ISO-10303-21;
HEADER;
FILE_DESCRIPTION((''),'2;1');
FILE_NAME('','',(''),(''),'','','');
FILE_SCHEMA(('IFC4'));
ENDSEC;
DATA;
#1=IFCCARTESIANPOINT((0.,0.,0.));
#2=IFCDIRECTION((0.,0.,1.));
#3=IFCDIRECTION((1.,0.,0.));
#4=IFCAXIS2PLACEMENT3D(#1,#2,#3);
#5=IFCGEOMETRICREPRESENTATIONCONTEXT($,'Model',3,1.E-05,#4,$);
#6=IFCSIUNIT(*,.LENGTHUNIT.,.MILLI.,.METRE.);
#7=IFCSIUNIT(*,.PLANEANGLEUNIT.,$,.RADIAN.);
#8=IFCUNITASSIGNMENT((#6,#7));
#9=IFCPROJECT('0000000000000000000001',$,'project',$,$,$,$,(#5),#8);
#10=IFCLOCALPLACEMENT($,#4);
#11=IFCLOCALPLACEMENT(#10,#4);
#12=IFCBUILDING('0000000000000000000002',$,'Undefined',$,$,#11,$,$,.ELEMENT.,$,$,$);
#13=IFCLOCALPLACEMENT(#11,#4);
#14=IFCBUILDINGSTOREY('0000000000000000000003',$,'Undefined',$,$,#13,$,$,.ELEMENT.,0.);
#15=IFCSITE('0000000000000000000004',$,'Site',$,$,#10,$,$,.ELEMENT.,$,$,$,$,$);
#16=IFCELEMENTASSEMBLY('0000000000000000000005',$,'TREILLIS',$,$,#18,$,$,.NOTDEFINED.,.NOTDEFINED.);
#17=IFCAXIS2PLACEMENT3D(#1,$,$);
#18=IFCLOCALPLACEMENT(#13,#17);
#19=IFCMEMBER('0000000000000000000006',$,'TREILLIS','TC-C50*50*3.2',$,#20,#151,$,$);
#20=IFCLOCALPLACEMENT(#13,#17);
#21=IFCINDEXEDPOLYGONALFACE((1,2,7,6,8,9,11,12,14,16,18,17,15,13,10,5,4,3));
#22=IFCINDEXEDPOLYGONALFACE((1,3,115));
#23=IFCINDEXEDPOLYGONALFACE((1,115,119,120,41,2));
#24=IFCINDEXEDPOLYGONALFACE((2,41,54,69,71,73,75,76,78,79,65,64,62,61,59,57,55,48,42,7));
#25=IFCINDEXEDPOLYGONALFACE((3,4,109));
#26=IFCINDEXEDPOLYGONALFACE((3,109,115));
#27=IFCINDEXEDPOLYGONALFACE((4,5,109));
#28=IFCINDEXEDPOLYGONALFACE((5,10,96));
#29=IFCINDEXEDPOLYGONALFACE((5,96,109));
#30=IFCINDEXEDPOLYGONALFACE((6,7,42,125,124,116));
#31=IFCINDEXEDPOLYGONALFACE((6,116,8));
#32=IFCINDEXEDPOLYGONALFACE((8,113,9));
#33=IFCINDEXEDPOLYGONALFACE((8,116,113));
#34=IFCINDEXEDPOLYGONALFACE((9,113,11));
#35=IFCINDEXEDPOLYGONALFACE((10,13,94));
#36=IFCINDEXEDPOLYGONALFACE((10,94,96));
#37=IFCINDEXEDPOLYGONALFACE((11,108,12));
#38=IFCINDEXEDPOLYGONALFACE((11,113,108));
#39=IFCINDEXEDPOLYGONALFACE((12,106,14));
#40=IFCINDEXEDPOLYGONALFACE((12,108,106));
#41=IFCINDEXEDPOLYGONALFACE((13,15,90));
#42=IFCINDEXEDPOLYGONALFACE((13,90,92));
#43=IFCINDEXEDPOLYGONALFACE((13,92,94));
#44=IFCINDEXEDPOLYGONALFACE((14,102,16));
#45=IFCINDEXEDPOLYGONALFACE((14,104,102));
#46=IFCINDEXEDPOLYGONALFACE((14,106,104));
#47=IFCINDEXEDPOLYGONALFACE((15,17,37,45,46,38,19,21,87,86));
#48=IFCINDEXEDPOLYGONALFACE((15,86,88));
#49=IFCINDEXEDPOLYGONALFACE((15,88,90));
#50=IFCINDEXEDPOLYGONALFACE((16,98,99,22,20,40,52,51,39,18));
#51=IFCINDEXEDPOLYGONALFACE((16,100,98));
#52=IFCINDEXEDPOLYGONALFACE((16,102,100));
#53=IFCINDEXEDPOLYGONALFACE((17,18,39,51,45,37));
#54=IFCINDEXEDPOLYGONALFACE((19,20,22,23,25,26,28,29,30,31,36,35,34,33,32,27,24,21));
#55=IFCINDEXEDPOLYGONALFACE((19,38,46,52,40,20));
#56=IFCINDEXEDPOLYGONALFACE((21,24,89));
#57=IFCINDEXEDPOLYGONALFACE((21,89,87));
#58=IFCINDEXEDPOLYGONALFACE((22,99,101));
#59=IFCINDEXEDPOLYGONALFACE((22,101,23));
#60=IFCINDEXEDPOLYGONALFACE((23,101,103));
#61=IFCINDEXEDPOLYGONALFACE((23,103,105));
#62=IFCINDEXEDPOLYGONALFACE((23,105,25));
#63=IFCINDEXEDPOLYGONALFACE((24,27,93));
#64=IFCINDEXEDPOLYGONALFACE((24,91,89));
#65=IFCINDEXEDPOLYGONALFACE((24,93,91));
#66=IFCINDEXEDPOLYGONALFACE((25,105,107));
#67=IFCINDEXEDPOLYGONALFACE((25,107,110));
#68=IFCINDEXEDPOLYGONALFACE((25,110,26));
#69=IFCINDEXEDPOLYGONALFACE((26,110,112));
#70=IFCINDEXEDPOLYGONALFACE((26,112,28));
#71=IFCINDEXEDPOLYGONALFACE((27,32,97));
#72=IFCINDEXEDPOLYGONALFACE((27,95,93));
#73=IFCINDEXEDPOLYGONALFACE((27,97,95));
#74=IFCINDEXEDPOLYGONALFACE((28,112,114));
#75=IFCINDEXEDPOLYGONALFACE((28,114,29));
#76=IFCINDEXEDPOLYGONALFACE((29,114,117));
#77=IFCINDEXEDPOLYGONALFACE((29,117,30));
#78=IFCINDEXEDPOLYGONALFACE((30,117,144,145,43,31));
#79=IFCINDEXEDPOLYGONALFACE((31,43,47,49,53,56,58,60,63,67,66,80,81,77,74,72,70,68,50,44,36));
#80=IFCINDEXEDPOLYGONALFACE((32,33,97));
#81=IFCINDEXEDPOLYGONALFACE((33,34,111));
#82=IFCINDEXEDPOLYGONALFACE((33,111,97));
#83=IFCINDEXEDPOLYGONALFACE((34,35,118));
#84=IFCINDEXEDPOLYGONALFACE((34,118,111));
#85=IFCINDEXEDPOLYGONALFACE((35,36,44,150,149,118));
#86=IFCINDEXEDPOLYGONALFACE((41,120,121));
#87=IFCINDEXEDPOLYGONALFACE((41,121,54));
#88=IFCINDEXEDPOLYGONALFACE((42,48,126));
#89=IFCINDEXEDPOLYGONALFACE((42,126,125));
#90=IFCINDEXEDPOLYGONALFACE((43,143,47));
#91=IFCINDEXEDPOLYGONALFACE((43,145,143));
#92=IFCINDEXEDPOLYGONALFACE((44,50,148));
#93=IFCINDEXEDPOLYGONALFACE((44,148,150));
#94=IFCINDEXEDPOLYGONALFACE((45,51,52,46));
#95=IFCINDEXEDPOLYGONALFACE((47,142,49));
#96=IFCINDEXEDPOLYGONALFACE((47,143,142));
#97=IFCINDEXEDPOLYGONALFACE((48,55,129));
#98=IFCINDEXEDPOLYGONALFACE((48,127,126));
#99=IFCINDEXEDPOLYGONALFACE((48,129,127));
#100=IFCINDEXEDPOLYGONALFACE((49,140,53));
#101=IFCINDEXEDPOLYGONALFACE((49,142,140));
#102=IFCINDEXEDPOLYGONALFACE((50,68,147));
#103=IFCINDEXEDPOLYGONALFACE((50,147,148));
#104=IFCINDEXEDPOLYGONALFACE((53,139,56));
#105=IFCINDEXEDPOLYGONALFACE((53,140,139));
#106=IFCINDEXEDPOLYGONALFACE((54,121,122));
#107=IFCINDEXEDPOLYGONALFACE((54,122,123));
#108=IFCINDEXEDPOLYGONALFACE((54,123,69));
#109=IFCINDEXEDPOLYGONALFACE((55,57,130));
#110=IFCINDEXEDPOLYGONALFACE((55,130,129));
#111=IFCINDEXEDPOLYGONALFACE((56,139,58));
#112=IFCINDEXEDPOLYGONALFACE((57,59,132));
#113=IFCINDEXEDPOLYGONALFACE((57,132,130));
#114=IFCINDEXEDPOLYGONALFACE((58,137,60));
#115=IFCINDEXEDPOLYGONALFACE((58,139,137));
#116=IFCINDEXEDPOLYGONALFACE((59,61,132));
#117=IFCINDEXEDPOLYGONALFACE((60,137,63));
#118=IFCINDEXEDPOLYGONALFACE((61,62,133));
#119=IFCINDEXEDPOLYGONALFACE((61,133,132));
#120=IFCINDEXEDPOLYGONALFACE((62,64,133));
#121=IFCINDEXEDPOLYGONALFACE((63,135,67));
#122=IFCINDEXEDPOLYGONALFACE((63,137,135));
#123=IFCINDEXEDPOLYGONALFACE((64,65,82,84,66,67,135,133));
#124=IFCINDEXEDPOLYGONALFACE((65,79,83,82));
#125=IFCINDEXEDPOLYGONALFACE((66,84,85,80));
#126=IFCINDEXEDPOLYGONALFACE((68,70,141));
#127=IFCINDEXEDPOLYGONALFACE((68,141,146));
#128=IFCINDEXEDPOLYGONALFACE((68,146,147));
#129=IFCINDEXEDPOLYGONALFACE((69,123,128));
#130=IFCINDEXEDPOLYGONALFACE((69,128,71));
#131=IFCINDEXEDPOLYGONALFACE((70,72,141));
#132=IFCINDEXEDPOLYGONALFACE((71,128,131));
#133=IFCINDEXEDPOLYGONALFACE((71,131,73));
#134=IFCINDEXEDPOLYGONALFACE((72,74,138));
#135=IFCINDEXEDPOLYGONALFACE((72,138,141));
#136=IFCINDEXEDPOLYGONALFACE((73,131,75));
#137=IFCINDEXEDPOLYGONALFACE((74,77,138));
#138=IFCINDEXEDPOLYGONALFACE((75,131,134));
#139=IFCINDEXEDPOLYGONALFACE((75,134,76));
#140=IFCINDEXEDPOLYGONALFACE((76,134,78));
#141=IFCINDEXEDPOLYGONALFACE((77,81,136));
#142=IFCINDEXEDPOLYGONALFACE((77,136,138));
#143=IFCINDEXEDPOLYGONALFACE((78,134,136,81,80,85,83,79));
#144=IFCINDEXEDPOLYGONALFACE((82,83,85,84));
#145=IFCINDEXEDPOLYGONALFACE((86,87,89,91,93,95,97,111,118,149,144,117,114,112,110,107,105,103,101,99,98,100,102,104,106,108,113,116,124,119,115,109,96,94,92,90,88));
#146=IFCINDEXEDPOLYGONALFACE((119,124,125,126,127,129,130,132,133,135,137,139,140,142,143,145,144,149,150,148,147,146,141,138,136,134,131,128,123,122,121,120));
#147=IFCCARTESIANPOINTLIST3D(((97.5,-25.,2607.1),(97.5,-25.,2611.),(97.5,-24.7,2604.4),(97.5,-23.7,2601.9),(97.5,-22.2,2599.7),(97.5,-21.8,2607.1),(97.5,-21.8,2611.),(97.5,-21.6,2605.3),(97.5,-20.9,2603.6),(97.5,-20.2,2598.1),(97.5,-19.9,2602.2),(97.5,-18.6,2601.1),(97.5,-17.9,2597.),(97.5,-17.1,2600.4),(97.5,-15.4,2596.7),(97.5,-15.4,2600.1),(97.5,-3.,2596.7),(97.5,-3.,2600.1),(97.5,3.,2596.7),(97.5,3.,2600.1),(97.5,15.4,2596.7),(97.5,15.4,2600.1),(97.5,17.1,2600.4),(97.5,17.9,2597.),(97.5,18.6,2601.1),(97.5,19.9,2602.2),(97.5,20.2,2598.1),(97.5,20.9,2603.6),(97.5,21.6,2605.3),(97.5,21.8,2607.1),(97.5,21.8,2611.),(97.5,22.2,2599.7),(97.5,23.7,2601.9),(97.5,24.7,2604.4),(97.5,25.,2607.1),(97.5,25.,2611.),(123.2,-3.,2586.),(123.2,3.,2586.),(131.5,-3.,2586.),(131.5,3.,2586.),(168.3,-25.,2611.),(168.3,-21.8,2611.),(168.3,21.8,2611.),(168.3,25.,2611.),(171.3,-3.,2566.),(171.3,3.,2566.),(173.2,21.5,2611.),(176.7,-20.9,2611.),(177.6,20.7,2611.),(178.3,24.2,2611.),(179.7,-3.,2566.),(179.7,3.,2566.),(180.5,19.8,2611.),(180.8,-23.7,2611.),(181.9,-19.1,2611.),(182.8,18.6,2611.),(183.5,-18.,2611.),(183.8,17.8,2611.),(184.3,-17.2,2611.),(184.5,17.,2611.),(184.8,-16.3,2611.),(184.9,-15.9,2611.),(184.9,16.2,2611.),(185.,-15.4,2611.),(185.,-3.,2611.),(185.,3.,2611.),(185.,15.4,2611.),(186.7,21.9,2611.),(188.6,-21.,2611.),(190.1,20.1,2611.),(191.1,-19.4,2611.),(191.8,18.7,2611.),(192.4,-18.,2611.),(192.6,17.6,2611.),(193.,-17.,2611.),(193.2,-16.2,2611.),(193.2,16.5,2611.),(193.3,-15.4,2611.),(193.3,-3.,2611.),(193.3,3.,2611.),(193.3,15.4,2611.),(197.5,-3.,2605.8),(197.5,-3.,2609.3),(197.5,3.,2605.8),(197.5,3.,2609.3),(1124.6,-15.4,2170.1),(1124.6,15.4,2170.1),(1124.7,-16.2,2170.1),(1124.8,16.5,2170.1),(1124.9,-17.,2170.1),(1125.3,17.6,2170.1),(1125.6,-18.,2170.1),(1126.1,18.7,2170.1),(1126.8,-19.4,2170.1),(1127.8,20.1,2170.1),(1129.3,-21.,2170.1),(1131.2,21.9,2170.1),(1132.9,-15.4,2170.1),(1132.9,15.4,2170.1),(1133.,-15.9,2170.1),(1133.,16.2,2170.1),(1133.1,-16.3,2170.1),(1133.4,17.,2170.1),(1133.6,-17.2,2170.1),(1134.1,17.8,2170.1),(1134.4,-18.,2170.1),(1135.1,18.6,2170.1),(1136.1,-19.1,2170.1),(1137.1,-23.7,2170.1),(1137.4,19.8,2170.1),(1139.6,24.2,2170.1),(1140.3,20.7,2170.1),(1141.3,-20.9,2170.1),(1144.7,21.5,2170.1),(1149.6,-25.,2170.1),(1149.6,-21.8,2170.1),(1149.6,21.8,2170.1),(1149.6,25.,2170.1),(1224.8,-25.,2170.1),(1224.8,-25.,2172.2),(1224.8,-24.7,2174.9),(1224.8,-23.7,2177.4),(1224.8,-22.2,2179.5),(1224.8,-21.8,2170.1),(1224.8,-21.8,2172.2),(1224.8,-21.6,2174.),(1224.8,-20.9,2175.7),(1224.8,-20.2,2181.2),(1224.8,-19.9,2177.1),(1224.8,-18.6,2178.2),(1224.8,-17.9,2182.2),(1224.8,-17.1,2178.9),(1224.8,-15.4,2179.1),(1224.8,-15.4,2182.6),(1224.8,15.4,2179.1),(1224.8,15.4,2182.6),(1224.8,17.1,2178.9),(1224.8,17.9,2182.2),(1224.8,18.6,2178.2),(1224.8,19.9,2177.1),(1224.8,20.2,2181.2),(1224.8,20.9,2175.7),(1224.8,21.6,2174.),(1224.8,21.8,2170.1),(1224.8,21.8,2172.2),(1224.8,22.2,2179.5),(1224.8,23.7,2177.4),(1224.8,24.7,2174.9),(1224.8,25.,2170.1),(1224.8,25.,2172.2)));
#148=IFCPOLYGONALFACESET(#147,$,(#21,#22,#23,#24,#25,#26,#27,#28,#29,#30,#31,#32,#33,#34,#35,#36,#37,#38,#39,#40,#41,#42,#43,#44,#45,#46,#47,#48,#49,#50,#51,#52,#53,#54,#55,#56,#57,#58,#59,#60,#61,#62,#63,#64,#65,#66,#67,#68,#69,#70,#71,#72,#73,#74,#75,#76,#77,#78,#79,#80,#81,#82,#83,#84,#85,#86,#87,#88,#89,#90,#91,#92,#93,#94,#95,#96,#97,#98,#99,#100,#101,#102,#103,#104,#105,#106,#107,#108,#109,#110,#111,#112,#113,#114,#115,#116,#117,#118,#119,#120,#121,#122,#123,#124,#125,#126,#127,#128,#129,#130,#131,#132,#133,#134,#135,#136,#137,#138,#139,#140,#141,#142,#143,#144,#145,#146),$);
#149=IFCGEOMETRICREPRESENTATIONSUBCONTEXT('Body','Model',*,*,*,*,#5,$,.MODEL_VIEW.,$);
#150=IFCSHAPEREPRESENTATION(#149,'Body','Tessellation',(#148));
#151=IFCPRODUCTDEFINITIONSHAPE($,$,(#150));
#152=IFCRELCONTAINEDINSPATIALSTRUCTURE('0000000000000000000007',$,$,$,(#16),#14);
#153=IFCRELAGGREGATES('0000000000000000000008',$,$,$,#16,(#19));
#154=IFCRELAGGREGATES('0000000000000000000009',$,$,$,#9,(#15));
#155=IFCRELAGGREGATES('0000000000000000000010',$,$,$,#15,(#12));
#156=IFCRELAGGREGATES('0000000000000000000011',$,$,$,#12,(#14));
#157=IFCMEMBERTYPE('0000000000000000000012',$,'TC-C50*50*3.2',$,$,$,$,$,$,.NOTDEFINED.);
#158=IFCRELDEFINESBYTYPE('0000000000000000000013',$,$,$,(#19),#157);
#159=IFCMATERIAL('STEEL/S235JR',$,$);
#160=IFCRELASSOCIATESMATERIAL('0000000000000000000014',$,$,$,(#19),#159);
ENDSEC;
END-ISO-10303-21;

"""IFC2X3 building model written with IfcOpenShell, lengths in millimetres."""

from ifc_helpers import new_model, si_unit, frame, origin_with_axes, origin_2d_with_axis, place, context, subcontext, project, spatial, rectangle, hollow_rectangle, extrude, boolean, halfspace, material, type_object, element, aggregate, save


model = new_model("IFC2X3")

# Units and contexts
model_context = context("Model", 3, precision=1e-05, world=origin_with_axes())
body_context = subcontext(model_context, "Body", "Model", "MODEL_VIEW")
ifc_project = project(units=[si_unit("LENGTHUNIT", "METRE", prefix="MILLI"), si_unit("PLANEANGLEUNIT", "RADIAN")], contexts=[model_context])

# Site, building, storey
site_placement = place(None, origin_with_axes())
site = spatial("IfcSite", under=ifc_project, at=site_placement, Name="Site", CompositionType="ELEMENT")
building_placement = place(site_placement, origin_with_axes())
building = spatial("IfcBuilding", under=site, at=building_placement, Name="Undefined", CompositionType="ELEMENT")
storey_placement = place(building_placement, origin_with_axes())
storey = spatial("IfcBuildingStorey", under=building, at=storey_placement, Name="Undefined", CompositionType="ELEMENT", Elevation=0.0)

# Shared definitions
ifc_material_1 = material(Name="STEEL/S235JR")

# Element assembly
assembly_1_placement = place(storey_placement, origin_with_axes())
assembly_1 = element("IfcElementAssembly", 1, at=assembly_1_placement, inside=storey, Name="TREILLIS", AssemblyPlace="NOTDEFINED", PredefinedType="NOTDEFINED")

# Member
member_type = type_object("IfcMemberType", Name="TC-C50*50*3.2", PredefinedType="NOTDEFINED")
member_1_placement = place(assembly_1_placement, frame((1249.8, 0.0, 2145.1), z_axis=(0.383566, 0.0, 0.923513), x_axis=(-0.923513, 0.0, 0.383566)))
solid = boolean("DIFFERENCE", boolean("DIFFERENCE", boolean("DIFFERENCE", boolean("DIFFERENCE", boolean("DIFFERENCE", boolean("DIFFERENCE", boolean("DIFFERENCE", boolean("DIFFERENCE", extrude(hollow_rectangle(XDim=50.0, YDim=50.0, WallThickness=3.2, InnerFilletRadius=6.4, OuterFilletRadius=9.6, at=origin_2d_with_axis()), frame((1280.0, 0.0, 0.0), z_axis=(-1.0, 0.0, 0.0), x_axis=(0.0, -1.0, 0.0)), (0.0, 0.0, 1.0), 1280.0), extrude(rectangle(XDim=6.0, YDim=100.0, at=origin_2d_with_axis()), frame((1152.4, 0.0, 31.2), z_axis=(0.923513, 0.0, -0.383566), x_axis=(0.0, 1.0, 0.0)), (0.0, 0.0, 1.0), 154.0)), extrude(rectangle(XDim=6.0, YDim=80.0, at=origin_2d_with_axis()), frame((1184.0, 0.0, 28.9), z_axis=(0.923513, 0.0, -0.383566), x_axis=(0.0, 1.0, 0.0)), (0.0, 0.0, 1.0), 124.0)), halfspace(frame((1237.4, -25.0, -25.0), z_axis=(0.923513, 0.0, -0.383566), x_axis=(0.383566, 0.0, 0.923513)), False)), halfspace(frame((16.4, 25.0, -25.8), z_axis=(-0.923459, 0.0, 0.383696), x_axis=(0.383696, 0.0, 0.923459)), False)), halfspace(frame((-1.2, -25.0, -25.0), z_axis=(0.0, -1.0, 0.0), x_axis=(0.047414, 0.0, 0.998875)), False)), halfspace(frame((-1.2, -25.0, -25.0), z_axis=(0.0, -1.0, 0.0), x_axis=(0.047414, 0.0, 0.998875)), False)), halfspace(frame((-1.2, -25.0, -25.0), z_axis=(0.0, -1.0, 0.0), x_axis=(0.047414, 0.0, 0.998875)), False)), halfspace(frame((131.2, 25.0, -27.5), z_axis=(-0.383566, 0.0, -0.923513), x_axis=(-0.923513, 0.0, 0.383566)), False))
member_1 = element("IfcMember", 2, at=member_1_placement, type_object=member_type, material=ifc_material_1, Name="TREILLIS", Description="TC-C50*50*3.2", context=body_context, shape_type="CSG", body=[
    boolean("DIFFERENCE", solid, halfspace(frame((1337.3, -25.0, -51.0), z_axis=(0.383566, 0.0, 0.923513), x_axis=(-0.923513, 0.0, 0.383566)), False)),
])

aggregate(assembly_1, [member_1])

save(model, "model.ifc")
